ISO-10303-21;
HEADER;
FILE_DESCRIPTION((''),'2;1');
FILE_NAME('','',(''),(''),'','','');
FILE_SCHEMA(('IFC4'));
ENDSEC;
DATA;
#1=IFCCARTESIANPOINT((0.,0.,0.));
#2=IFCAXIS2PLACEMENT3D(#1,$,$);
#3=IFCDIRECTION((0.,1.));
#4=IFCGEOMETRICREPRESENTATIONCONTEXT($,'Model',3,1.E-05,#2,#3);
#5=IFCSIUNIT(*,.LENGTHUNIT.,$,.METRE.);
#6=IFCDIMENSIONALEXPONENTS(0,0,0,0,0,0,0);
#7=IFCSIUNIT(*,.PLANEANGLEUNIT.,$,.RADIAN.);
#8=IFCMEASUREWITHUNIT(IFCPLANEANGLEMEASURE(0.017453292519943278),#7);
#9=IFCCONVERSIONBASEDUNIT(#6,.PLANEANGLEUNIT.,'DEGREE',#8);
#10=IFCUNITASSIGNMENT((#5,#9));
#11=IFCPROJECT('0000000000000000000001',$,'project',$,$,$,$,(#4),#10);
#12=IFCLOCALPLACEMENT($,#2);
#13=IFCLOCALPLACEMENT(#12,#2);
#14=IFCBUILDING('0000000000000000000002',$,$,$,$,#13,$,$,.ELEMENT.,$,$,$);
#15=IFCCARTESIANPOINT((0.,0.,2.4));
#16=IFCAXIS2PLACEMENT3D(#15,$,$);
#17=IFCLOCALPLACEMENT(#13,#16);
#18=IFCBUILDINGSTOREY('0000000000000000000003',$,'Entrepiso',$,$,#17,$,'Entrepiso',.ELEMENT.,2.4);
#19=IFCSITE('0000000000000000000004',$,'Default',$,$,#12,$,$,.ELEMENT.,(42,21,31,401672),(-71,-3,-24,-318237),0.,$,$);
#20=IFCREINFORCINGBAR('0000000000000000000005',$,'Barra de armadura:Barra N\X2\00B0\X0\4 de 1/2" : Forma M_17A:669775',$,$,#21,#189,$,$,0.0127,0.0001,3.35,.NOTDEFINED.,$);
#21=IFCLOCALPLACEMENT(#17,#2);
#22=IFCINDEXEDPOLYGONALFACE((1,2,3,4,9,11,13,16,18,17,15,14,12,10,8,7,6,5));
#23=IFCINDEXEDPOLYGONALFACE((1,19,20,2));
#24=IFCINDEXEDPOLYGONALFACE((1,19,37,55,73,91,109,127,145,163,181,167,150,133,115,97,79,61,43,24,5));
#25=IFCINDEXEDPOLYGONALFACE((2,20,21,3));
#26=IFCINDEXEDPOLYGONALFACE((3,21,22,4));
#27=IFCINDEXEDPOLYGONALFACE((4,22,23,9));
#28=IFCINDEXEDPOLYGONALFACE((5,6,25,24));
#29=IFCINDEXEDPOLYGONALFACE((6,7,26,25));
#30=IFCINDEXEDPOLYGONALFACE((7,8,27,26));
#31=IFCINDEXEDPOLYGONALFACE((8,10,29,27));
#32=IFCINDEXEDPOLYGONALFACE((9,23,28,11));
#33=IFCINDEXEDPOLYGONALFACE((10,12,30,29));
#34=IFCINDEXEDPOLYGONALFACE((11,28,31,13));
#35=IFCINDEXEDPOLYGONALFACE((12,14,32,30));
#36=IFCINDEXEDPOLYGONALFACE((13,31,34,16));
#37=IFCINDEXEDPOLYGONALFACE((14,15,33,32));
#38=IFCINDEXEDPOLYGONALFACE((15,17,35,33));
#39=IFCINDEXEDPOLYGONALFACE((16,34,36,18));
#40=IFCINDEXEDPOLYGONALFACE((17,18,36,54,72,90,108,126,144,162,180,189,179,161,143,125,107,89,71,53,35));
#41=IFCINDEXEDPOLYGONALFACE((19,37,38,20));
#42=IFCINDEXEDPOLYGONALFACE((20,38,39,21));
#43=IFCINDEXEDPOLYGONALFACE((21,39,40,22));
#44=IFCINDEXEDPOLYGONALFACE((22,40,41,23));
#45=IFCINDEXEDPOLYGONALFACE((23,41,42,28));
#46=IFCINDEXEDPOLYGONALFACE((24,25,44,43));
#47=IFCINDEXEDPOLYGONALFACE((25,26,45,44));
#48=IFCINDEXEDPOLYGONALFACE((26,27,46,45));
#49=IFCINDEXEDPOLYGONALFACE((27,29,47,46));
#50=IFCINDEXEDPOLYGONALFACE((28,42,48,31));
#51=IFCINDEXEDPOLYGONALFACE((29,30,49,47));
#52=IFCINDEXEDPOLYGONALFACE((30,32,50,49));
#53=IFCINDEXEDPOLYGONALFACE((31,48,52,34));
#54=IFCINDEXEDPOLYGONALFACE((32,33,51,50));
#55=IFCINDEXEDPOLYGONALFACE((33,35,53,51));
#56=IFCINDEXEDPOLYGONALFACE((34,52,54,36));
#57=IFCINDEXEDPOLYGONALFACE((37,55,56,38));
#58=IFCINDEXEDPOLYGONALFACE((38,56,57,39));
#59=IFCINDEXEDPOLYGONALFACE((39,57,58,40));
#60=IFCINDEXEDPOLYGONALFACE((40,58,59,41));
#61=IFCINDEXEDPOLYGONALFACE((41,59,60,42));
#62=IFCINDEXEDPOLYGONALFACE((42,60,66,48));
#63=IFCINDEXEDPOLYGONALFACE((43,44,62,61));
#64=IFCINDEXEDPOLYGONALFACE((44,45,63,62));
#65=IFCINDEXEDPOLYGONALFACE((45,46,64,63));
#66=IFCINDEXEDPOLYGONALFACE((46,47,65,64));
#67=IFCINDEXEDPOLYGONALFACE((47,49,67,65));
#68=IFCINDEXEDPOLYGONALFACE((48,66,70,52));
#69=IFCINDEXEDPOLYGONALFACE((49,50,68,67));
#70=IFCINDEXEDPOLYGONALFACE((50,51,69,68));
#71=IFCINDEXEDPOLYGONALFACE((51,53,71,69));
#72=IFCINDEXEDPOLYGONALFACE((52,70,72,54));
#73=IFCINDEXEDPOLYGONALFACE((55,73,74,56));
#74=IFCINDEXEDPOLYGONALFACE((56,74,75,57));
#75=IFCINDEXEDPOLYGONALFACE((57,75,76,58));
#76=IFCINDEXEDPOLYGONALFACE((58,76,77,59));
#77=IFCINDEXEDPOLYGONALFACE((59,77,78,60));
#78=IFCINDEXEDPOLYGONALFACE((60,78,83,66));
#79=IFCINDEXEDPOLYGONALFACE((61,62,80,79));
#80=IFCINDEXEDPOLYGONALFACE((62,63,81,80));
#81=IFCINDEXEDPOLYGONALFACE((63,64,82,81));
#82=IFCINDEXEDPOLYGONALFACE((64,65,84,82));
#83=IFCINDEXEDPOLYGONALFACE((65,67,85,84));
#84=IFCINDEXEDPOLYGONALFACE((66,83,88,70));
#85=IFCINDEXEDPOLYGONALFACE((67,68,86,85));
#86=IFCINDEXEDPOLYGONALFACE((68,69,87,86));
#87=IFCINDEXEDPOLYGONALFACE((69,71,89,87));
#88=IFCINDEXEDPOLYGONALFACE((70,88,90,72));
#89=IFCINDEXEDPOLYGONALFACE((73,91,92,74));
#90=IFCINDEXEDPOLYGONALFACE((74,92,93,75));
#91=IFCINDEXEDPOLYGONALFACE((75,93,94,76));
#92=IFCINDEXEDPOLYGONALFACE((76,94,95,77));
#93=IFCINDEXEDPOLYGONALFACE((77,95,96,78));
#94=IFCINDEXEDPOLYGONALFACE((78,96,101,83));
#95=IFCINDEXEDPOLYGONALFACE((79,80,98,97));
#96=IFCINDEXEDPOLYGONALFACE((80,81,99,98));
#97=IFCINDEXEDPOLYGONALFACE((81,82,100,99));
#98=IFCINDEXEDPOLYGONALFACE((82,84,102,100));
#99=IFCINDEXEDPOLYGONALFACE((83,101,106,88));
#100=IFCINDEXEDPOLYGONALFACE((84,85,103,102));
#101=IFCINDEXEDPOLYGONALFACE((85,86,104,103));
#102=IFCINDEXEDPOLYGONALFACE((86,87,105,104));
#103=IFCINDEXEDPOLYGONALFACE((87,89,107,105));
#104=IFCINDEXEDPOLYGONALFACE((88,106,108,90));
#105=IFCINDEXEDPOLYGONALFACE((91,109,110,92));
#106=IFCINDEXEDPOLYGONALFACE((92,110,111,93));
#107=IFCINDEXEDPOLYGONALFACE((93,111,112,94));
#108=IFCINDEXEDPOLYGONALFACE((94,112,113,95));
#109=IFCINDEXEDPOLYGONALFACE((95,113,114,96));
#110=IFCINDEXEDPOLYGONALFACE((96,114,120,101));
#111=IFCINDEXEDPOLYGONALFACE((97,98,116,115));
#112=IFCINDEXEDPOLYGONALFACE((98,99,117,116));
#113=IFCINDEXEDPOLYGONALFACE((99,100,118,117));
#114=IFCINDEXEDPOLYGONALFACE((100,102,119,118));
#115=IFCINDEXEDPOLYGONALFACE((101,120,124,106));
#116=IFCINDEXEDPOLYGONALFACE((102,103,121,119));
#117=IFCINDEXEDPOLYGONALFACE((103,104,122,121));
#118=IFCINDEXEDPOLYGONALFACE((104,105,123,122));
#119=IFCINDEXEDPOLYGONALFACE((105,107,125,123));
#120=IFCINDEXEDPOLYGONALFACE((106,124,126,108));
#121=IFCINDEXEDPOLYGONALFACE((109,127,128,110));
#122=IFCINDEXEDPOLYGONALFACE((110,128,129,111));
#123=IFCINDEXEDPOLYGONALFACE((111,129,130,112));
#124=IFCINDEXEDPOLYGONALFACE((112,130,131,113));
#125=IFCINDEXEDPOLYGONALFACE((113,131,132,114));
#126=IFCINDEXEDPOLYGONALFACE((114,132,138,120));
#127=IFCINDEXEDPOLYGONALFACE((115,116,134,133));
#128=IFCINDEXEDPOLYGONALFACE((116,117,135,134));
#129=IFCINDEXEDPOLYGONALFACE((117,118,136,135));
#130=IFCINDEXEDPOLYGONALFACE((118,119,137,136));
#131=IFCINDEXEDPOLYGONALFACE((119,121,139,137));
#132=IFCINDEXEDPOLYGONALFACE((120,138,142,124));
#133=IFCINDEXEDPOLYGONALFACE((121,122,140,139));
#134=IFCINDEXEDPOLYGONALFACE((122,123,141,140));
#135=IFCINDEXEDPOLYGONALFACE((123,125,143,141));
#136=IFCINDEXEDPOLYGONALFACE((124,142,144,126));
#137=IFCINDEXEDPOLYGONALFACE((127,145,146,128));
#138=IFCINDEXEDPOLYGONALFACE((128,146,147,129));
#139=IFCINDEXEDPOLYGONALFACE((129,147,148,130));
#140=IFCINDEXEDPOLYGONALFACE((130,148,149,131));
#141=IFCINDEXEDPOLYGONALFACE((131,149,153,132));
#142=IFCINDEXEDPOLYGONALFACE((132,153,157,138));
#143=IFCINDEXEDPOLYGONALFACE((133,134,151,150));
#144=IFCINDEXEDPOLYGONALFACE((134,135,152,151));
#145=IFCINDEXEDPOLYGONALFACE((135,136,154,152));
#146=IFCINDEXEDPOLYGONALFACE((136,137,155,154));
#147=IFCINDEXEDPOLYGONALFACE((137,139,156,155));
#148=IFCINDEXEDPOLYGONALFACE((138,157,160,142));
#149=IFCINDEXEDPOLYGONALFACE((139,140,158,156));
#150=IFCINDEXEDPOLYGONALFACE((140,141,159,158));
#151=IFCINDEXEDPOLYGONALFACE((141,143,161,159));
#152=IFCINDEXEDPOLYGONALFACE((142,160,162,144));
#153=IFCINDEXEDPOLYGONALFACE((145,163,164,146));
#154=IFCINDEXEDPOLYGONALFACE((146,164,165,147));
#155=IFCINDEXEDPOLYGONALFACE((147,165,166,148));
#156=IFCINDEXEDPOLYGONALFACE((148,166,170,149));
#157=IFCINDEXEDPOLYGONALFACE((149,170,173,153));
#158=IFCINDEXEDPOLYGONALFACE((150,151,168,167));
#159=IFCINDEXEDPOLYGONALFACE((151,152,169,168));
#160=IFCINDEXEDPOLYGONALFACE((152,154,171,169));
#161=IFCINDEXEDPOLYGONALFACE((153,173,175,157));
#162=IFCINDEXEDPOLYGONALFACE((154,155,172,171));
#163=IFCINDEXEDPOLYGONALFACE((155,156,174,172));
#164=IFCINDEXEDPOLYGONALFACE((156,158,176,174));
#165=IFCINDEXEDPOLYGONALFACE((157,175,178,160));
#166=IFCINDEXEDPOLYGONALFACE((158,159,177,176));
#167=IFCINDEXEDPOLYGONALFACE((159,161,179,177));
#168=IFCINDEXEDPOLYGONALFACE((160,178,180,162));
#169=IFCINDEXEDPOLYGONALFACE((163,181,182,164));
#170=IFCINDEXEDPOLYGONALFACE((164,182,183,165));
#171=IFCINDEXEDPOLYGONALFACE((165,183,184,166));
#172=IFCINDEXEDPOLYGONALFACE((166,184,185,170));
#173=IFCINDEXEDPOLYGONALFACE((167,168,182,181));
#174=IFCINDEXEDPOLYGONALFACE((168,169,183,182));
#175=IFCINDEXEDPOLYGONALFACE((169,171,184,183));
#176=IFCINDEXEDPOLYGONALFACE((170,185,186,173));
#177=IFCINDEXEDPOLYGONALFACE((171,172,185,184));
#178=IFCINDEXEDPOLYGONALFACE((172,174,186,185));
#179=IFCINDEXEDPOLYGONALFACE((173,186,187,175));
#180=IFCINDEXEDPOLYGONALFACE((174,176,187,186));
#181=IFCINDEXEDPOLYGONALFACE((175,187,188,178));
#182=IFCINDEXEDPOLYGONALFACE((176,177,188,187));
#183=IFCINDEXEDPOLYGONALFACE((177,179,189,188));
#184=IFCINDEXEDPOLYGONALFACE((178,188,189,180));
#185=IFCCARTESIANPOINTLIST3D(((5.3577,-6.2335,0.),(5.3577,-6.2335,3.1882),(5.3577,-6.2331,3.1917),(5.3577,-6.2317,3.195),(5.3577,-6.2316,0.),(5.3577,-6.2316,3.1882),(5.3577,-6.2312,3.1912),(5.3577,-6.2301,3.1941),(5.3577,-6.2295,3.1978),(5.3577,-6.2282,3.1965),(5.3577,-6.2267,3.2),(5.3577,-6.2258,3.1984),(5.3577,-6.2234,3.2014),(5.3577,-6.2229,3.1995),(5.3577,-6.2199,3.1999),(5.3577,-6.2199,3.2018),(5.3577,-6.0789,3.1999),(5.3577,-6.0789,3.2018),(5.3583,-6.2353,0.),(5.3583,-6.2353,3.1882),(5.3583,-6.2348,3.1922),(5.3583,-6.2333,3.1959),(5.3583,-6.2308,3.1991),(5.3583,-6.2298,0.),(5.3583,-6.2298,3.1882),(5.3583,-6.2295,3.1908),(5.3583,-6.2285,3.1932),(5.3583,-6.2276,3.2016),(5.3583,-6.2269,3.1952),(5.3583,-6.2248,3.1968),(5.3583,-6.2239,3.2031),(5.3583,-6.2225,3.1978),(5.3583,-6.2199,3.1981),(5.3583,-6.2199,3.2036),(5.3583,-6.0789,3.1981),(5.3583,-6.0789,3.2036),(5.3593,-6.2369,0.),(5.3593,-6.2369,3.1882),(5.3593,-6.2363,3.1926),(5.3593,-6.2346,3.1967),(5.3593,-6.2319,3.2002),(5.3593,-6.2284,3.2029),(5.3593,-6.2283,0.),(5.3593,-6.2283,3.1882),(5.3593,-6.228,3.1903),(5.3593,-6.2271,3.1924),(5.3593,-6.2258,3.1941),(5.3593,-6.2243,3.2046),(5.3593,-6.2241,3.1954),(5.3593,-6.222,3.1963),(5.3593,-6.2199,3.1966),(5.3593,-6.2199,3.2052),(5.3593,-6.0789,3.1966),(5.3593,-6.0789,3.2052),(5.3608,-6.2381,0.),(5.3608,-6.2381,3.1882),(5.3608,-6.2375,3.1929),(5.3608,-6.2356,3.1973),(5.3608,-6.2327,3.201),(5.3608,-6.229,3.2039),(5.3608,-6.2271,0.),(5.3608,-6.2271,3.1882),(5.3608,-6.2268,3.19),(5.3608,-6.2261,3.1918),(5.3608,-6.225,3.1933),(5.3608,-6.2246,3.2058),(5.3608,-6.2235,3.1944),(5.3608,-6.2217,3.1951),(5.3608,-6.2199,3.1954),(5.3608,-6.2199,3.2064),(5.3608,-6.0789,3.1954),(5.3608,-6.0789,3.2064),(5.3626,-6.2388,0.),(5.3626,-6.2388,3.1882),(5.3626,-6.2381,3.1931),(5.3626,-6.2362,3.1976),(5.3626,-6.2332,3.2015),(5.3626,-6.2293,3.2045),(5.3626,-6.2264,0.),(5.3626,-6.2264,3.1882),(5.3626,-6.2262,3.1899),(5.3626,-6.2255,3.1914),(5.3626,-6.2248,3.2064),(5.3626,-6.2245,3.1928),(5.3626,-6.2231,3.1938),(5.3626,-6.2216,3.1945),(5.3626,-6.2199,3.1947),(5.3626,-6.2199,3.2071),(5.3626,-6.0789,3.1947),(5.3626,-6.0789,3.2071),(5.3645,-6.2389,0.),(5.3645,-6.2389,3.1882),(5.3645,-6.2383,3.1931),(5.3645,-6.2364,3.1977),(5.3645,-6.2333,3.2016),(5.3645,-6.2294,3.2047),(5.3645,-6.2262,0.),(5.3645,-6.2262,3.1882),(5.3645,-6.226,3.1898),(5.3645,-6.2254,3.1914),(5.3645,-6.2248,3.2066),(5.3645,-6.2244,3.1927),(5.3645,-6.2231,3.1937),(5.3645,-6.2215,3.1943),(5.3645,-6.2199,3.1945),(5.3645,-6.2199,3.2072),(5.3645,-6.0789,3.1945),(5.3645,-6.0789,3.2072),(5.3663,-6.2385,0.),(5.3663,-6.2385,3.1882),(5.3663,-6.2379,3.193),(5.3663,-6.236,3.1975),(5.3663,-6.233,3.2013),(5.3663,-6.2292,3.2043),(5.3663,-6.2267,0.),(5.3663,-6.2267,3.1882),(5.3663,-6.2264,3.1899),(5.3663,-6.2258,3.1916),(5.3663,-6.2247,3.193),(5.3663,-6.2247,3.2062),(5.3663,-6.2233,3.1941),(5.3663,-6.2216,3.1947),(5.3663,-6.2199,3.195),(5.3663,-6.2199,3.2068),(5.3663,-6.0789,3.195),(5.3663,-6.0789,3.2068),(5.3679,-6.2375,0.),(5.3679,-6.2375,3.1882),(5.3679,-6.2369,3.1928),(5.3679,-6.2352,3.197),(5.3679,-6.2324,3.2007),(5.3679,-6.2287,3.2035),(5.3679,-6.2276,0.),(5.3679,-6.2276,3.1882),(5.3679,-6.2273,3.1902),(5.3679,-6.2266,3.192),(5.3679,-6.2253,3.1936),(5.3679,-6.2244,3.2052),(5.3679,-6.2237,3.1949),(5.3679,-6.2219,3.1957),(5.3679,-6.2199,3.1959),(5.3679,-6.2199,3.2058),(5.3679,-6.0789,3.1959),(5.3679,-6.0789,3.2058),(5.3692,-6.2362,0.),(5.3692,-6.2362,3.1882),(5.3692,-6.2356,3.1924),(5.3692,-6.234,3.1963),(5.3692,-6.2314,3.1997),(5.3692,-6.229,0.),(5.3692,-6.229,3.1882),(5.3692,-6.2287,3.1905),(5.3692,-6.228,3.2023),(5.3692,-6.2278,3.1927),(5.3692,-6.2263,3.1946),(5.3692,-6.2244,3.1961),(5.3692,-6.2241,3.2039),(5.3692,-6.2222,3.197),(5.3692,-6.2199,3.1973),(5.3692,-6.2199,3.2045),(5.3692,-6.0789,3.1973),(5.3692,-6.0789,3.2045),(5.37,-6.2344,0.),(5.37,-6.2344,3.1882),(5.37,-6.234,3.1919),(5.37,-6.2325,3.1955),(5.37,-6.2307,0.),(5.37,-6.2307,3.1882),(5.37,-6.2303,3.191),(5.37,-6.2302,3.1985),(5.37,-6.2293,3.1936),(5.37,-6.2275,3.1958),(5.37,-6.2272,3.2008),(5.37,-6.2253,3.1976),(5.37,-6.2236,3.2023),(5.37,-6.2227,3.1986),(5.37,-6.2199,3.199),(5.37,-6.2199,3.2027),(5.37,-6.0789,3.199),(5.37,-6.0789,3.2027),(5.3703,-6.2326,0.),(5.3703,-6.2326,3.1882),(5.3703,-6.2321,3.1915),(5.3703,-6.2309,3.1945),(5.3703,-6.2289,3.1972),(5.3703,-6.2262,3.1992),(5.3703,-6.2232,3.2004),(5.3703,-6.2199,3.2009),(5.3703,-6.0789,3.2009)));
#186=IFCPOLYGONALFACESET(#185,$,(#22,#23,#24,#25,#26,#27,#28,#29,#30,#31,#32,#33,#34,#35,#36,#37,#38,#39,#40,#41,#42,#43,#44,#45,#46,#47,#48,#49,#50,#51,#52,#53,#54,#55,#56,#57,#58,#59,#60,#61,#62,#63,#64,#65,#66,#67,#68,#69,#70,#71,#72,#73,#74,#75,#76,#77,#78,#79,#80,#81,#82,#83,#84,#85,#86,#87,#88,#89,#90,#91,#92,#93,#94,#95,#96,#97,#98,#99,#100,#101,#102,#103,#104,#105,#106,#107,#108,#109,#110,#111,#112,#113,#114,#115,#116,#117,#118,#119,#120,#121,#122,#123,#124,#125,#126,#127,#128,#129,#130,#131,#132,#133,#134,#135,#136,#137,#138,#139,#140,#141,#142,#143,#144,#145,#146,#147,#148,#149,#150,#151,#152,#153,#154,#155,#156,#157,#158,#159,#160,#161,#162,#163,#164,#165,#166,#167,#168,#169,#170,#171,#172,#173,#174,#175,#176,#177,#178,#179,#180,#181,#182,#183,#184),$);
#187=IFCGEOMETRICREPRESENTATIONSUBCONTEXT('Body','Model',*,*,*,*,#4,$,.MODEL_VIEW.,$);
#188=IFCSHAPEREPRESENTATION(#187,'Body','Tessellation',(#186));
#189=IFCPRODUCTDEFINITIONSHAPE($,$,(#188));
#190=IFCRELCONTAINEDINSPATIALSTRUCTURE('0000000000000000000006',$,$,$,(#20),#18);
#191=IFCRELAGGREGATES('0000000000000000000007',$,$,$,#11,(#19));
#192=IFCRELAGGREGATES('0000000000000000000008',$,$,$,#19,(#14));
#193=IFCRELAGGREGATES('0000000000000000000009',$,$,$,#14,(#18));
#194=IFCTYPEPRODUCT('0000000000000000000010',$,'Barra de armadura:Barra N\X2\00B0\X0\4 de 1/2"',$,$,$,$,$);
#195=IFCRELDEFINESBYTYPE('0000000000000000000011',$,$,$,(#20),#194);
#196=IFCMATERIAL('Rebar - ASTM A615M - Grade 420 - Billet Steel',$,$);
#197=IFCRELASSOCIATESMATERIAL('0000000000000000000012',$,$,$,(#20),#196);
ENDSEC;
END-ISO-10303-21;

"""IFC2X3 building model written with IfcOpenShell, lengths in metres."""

from ifc_helpers import new_model, entity, si_unit, converted_unit, direction, frame, origin, place, context, subcontext, project, spatial, material, type_object, element, save


model = new_model("IFC2X3")

# Units and contexts
model_context = context("Model", 3, precision=1e-05, world=origin(), true_north=direction((0.0, 1.0)))
body_context = subcontext(model_context, "Body", "Model", "MODEL_VIEW")
ifc_project = project(units=[si_unit("LENGTHUNIT", "METRE"), converted_unit("PLANEANGLEUNIT", "DEGREE", entity("IfcPlaneAngleMeasure", 0.017453292519943278), si_unit("PLANEANGLEUNIT", "RADIAN"), dimensions=[0, 0, 0, 0, 0, 0, 0])], contexts=[model_context])

# Site, building, storey
site_placement = place(None, origin())
site = spatial("IfcSite", under=ifc_project, at=site_placement, Name="Default", CompositionType="ELEMENT", RefLatitude=(42, 21, 31, 401672), RefLongitude=(-71, -3, -24, -318237), RefElevation=0.0)
building_placement = place(site_placement, origin())
building = spatial("IfcBuilding", under=site, at=building_placement, CompositionType="ELEMENT")
storey_placement = place(building_placement, frame((0.0, 0.0, 2.4)))
storey = spatial("IfcBuildingStorey", under=building, at=storey_placement, Name="Entrepiso", LongName="Entrepiso", CompositionType="ELEMENT", Elevation=2.4)

# Reinforcing bar
ifc_material = material(Name="Rebar - ASTM A615M - Grade 420 - Billet Steel")
type_product_1 = type_object("IfcTypeProduct", Name="Barra de armadura:Barra N°4 de 1/2\"")
reinforcing_bar_1_placement = place(storey_placement, origin())
element("IfcReinforcingBar", 1, at=reinforcing_bar_1_placement, inside=storey, type_object=type_product_1, material=ifc_material, Name="Barra de armadura:Barra N°4 de 1/2\" : Forma M_17A:669775", BarLength=3.35, BarRole="NOTDEFINED", CrossSectionArea=0.0001, NominalDiameter=0.0127, context=body_context, shape_type="AdvancedSweptSolid", body=[
    entity("IfcSweptDiskSolid", entity("IfcCompositeCurve", [entity("IfcCompositeCurveSegment", "CONTINUOUS", True, entity("IfcPolyline", [entity("IfcCartesianPoint", [5.364, -6.2326, 0.0]), entity("IfcCartesianPoint", [5.364, -6.2326, 3.1882])])), entity("IfcCompositeCurveSegment", "CONTINUOUS", True, entity("IfcTrimmedCurve", entity("IfcCircle", entity("IfcAxis2Placement3D", entity("IfcCartesianPoint", [5.364, -6.2199, 3.1882]), entity("IfcDirection", [-1.0, 0.0, 0.0]), entity("IfcDirection", [0.0, 0.0, 1.0])), 0.0127), [entity("IfcParameterValue", 270.0)], [entity("IfcParameterValue", 360.0)], True, "PARAMETER")), entity("IfcCompositeCurveSegment", "CONTINUOUS", True, entity("IfcPolyline", [entity("IfcCartesianPoint", [5.364, -6.2199, 3.2009]), entity("IfcCartesianPoint", [5.364, -6.0789, 3.2009])]))], False), 0.0063, None, 0.0, 92.0),
])

save(model, "model.ifc")
